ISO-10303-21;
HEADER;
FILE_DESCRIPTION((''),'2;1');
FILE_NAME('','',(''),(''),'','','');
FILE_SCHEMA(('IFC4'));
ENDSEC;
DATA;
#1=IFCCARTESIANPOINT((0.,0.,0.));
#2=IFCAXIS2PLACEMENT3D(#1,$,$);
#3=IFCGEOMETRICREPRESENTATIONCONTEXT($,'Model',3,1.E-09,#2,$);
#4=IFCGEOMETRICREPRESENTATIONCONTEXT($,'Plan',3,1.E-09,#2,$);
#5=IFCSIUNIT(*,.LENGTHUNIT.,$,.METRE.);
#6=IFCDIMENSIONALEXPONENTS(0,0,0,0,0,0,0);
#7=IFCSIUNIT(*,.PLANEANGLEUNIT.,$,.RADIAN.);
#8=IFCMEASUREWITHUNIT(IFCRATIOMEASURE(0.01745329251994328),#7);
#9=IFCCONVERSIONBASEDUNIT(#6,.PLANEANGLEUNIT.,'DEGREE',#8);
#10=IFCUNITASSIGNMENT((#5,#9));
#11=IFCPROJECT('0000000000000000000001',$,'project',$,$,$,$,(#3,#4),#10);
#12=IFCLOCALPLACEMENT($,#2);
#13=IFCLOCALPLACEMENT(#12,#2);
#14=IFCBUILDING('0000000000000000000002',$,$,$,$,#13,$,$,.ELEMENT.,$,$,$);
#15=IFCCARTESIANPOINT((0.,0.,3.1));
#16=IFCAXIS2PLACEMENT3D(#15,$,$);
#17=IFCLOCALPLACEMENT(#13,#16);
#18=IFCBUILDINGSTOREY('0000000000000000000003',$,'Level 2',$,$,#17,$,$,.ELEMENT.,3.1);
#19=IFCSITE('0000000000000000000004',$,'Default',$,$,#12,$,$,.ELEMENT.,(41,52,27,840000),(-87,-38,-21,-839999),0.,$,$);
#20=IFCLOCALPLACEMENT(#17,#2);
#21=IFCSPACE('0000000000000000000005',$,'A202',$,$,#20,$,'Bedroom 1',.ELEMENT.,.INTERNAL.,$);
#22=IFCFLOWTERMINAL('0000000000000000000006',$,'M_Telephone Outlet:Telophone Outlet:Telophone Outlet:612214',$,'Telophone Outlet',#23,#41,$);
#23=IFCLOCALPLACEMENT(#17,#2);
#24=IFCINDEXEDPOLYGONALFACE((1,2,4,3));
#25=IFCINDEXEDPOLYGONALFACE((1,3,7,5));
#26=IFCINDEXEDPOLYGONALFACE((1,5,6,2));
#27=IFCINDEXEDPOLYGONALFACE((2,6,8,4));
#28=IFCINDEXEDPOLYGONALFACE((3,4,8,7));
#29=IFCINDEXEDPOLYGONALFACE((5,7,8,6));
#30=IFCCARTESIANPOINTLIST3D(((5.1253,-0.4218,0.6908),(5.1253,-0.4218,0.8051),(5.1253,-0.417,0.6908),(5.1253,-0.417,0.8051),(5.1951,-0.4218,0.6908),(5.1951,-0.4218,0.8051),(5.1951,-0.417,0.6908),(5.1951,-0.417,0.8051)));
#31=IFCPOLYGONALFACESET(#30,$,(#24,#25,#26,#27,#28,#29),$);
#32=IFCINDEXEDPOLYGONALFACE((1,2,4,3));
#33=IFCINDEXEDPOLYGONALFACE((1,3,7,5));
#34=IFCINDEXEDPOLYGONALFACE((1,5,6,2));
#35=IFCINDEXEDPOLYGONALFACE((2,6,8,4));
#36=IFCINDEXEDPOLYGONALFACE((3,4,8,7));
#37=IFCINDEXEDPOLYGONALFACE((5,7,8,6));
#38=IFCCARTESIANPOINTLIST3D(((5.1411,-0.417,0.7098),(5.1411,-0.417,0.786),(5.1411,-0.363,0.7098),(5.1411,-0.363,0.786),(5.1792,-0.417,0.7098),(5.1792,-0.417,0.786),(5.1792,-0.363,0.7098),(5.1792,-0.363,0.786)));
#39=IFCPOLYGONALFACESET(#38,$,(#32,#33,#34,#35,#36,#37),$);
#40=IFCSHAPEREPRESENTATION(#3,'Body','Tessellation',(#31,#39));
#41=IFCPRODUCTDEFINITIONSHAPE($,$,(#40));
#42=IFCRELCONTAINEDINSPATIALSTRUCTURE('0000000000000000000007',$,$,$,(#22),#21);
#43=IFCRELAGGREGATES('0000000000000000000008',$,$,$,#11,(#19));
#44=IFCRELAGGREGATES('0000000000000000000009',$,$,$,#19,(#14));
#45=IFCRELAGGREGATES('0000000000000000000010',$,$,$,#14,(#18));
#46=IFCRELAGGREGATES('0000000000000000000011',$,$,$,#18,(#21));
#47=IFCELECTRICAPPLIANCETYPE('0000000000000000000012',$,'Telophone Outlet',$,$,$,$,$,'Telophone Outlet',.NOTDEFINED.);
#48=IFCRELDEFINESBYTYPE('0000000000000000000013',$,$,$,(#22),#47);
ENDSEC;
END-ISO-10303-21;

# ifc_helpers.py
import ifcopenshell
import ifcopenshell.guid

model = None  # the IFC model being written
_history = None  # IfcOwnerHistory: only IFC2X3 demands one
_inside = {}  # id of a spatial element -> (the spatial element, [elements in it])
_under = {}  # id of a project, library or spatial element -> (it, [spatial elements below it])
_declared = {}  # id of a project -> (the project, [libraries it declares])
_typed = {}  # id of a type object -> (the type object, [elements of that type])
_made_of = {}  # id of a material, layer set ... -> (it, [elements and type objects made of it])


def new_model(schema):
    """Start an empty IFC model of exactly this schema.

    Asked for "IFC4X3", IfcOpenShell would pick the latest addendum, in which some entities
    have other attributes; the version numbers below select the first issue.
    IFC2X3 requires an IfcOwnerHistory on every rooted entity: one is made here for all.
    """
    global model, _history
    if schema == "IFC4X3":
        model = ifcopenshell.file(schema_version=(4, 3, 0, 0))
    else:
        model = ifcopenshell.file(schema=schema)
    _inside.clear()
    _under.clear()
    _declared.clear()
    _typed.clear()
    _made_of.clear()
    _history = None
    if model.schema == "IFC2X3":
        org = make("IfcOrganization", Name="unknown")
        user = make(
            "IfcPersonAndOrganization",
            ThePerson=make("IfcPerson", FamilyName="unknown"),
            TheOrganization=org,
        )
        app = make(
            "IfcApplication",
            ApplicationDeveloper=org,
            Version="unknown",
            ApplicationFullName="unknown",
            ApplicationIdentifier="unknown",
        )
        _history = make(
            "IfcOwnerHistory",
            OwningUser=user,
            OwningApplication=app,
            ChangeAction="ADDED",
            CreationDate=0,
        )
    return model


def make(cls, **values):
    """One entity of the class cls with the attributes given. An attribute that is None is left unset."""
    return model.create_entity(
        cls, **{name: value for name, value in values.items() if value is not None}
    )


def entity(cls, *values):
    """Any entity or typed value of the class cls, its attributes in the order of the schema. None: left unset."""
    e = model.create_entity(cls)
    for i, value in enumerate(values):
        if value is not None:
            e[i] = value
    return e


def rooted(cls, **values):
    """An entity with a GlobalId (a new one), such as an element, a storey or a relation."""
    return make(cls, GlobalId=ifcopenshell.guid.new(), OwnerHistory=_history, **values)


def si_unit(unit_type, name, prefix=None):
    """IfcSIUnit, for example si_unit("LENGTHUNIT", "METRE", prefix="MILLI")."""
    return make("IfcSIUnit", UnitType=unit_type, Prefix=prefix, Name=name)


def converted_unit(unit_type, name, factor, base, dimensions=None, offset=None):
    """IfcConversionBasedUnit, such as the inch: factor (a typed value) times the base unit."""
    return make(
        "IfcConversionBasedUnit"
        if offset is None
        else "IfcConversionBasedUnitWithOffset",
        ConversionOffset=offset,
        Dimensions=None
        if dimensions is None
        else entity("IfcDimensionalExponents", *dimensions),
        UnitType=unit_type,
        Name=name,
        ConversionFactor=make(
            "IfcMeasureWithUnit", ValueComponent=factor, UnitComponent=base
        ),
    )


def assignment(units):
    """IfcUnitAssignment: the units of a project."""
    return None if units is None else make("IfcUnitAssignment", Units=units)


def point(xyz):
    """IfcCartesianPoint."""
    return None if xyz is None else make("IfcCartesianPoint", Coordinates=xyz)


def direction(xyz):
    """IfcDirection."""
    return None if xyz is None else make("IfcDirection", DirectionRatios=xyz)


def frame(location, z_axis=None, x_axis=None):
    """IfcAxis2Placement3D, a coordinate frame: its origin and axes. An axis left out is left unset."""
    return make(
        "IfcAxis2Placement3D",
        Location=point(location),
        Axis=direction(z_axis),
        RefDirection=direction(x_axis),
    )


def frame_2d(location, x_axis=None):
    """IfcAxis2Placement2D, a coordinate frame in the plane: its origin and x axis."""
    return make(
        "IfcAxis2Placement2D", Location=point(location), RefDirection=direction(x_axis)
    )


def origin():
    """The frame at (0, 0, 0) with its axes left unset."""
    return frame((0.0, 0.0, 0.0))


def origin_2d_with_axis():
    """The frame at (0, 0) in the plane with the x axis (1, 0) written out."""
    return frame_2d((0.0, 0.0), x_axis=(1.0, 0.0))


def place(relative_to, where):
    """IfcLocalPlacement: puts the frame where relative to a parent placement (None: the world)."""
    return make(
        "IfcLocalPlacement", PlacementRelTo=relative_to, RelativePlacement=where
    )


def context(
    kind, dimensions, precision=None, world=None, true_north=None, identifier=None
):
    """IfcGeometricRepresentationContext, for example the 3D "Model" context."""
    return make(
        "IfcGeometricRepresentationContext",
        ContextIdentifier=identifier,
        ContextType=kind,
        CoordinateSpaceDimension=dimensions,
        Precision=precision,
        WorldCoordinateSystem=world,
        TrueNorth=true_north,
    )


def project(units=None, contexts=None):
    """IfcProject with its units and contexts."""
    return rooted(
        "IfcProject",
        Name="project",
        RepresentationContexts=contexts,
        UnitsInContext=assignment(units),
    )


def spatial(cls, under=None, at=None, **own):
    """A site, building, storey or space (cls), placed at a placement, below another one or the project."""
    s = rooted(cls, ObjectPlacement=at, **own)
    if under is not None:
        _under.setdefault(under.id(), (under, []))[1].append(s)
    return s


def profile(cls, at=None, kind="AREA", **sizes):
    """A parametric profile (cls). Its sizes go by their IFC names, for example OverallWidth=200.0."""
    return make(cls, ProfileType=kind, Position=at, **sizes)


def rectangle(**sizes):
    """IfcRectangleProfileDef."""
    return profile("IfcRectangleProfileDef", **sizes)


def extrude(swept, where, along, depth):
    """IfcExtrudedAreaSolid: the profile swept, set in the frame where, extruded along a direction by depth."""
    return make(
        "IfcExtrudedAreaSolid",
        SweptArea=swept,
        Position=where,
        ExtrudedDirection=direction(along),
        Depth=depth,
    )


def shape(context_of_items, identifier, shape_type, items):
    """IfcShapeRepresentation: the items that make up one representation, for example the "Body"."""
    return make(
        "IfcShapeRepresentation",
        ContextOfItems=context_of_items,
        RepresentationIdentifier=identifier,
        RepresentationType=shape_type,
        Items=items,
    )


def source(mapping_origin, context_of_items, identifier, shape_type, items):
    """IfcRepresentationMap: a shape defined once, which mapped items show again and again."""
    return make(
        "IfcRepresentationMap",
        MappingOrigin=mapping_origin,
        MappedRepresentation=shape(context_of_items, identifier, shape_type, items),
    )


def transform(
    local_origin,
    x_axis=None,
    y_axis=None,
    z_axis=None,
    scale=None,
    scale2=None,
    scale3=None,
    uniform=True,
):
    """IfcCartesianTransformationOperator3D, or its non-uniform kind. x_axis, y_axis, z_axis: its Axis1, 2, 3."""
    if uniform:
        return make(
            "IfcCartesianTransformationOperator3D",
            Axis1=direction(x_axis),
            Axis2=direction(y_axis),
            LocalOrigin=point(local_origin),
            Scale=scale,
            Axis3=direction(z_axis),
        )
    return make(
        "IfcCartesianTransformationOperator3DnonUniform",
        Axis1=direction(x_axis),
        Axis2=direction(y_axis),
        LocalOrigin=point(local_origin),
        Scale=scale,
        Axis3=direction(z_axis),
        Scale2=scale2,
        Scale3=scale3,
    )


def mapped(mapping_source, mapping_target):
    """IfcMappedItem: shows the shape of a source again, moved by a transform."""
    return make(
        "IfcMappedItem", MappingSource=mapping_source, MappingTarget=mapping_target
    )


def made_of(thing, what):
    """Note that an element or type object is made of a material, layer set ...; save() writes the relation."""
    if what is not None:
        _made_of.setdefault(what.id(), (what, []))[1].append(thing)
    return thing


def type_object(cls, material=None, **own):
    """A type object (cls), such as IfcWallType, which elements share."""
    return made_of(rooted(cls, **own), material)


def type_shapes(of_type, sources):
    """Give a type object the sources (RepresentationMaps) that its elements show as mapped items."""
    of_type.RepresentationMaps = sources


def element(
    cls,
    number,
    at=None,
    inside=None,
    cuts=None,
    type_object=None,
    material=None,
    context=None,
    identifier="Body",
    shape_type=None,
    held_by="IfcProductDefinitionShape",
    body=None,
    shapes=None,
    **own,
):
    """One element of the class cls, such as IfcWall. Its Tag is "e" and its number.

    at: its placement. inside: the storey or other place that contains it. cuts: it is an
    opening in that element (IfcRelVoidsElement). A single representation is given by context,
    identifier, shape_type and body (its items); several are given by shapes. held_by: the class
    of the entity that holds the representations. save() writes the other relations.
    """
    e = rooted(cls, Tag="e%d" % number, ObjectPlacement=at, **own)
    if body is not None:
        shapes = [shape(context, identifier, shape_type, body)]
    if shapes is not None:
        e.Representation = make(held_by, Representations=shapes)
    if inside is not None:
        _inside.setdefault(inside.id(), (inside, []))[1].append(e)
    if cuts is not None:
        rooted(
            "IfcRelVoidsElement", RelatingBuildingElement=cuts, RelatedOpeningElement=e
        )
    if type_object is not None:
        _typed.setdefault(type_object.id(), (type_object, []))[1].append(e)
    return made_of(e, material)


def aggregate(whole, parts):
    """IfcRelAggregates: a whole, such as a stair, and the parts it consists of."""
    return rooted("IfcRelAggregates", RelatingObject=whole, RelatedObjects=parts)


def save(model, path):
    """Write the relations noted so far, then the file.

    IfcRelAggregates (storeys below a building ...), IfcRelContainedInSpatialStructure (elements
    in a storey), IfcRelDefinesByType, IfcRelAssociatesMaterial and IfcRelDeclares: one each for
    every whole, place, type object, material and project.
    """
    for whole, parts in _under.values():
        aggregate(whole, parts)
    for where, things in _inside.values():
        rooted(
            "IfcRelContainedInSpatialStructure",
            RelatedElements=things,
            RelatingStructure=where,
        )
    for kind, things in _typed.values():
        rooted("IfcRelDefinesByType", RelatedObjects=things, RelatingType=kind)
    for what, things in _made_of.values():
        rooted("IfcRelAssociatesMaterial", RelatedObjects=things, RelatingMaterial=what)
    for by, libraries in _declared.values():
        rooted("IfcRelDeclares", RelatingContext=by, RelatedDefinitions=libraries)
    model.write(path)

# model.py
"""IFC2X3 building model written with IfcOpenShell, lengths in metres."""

from ifc_helpers import new_model, entity, si_unit, converted_unit, frame, origin, origin_2d_with_axis, place, context, project, spatial, rectangle, extrude, source, transform, mapped, type_object, type_shapes, element, save


model = new_model("IFC2X3")

# Units and contexts
model_context = context("Model", 3, precision=1e-09, world=origin())
plan_context = context("Plan", 3, precision=1e-09, world=origin())
ifc_project = project(units=[si_unit("LENGTHUNIT", "METRE"), converted_unit("PLANEANGLEUNIT", "DEGREE", entity("IfcRatioMeasure", 0.01745329251994328), si_unit("PLANEANGLEUNIT", "RADIAN"), dimensions=[0, 0, 0, 0, 0, 0, 0])], contexts=[model_context, plan_context])

# Site, building, storey
site_placement = place(None, origin())
site = spatial("IfcSite", under=ifc_project, at=site_placement, Name="Default", CompositionType="ELEMENT", RefLatitude=(41, 52, 27, 840000), RefLongitude=(-87, -38, -21, -839999), RefElevation=0.0)
building_placement = place(site_placement, origin())
building = spatial("IfcBuilding", under=site, at=building_placement, CompositionType="ELEMENT")
storey_placement = place(building_placement, frame((0.0, 0.0, 3.1)))
storey = spatial("IfcBuildingStorey", under=building, at=storey_placement, Name="Level 2", CompositionType="ELEMENT", Elevation=3.1)

# Shared definitions
space_1_placement = place(storey_placement, origin())
space_1 = spatial("IfcSpace", under=storey, at=space_1_placement, Name="A202", LongName="Bedroom 1", CompositionType="ELEMENT", InteriorOrExteriorSpace="INTERNAL")

# Flow terminal
electric_appliance_type = type_object("IfcElectricApplianceType", Name="Telophone Outlet", ElementType="Telophone Outlet", PredefinedType="NOTDEFINED")
shared_shape_1 = source(origin(), model_context, "Body", "SweptSolid", [
    extrude(rectangle(XDim=0.0699, YDim=0.1143, at=origin_2d_with_axis()), frame((0.0, 0.0, 0.0), z_axis=(0.0, 0.0, 1.0), x_axis=(-1.0, 0.0, 0.0)), (0.0, 0.0, 1.0), 0.0048),
    extrude(rectangle(XDim=0.0381, YDim=0.0762, at=origin_2d_with_axis()), frame((0.0, 0.0, -0.054), z_axis=(0.0, 0.0, 1.0), x_axis=(-1.0, 0.0, 0.0)), (0.0, 0.0, 1.0), 0.054),
])
type_shapes(electric_appliance_type, [shared_shape_1])
flow_terminal_1_placement = place(space_1_placement, frame((5.1602, -0.417, 0.7479), z_axis=(0.0, -1.0, 0.0), x_axis=(1.0, 0.0, 0.0)))
element("IfcFlowTerminal", 1, at=flow_terminal_1_placement, inside=space_1, type_object=electric_appliance_type, Name="M_Telephone Outlet:Telophone Outlet:Telophone Outlet:612214", ObjectType="Telophone Outlet", context=model_context, shape_type="MappedRepresentation", body=[
    mapped(shared_shape_1, transform((0.0, 0.0, 0.0), scale=1.0)),
])

save(model, "model.ifc")
